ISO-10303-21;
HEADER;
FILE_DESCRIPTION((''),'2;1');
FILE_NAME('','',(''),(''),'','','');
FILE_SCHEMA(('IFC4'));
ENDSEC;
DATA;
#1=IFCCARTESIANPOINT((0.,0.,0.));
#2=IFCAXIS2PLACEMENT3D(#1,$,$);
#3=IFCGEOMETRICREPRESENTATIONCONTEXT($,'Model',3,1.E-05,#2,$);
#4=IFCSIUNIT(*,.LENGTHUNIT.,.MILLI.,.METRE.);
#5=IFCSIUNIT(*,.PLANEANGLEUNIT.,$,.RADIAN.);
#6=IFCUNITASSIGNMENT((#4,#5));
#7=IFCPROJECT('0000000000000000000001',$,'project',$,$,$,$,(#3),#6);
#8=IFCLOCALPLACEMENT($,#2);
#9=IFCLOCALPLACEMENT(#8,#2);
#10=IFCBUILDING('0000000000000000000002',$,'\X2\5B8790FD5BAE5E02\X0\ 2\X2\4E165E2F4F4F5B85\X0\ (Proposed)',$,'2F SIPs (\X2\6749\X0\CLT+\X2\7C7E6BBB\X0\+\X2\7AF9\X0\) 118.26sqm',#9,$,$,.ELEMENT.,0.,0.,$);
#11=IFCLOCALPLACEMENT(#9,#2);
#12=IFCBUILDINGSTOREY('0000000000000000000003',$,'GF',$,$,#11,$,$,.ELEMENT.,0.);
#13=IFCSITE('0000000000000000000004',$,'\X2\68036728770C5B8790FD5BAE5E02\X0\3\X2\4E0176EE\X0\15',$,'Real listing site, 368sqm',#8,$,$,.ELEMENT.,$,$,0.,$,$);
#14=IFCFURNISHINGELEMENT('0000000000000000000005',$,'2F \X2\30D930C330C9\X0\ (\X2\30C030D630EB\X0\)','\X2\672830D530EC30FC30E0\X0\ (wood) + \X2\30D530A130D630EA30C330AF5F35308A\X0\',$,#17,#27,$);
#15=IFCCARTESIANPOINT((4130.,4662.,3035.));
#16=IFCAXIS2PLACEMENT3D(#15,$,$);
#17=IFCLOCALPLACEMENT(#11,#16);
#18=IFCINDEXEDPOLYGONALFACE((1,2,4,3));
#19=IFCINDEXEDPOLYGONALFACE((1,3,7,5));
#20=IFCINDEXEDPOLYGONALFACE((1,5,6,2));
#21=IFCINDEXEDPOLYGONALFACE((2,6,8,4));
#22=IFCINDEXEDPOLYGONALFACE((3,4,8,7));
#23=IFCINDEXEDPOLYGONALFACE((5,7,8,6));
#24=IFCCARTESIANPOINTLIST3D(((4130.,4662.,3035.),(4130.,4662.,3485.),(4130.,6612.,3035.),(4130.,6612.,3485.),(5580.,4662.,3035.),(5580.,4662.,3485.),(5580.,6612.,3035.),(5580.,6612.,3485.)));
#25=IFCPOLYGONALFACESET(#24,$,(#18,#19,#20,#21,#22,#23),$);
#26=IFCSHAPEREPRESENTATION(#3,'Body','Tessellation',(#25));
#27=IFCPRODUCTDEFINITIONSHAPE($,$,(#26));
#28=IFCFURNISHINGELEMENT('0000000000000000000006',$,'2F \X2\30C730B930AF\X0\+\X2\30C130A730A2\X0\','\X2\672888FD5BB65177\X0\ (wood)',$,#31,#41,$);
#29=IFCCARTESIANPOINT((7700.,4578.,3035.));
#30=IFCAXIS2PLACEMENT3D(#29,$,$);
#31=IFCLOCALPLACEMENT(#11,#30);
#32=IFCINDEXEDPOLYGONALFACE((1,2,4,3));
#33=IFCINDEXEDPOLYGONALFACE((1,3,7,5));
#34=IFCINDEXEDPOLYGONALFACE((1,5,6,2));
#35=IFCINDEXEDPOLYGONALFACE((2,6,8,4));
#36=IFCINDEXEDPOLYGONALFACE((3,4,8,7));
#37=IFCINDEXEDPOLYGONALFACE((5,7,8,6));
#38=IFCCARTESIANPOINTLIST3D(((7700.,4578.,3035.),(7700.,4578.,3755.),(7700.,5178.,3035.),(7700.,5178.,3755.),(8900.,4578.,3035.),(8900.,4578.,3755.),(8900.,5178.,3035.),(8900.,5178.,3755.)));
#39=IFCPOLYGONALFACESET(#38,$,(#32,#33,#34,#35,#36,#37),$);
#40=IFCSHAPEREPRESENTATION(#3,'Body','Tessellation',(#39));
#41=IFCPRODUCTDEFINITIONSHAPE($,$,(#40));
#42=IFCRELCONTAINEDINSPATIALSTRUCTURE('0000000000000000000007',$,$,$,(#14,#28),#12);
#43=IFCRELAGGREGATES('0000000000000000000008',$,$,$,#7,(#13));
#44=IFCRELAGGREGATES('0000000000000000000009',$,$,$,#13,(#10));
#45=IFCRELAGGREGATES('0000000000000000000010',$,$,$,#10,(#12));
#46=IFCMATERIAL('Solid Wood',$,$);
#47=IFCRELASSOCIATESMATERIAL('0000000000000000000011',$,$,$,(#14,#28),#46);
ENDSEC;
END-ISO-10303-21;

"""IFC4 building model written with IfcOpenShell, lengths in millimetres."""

from ifc_helpers import new_model, si_unit, frame, frame_2d, origin, place, context, project, spatial, rectangle, extrude, material, element, save


model = new_model("IFC4")

# Units and contexts
model_context = context("Model", 3, precision=1e-05, world=origin())
ifc_project = project(units=[si_unit("LENGTHUNIT", "METRE", prefix="MILLI"), si_unit("PLANEANGLEUNIT", "RADIAN")], contexts=[model_context])

# Site, building, storey
site_placement = place(None, origin())
site = spatial("IfcSite", under=ifc_project, at=site_placement, Name="栃木県宇都宮市3丁目15", ObjectType="Real listing site, 368sqm", CompositionType="ELEMENT", RefElevation=0.0)
building_placement = place(site_placement, origin())
building = spatial("IfcBuilding", under=site, at=building_placement, Name="宇都宮市 2世帯住宅 (Proposed)", ObjectType="2F SIPs (杉CLT+籾殻+竹) 118.26sqm", CompositionType="ELEMENT", ElevationOfRefHeight=0.0, ElevationOfTerrain=0.0)
storey_placement = place(building_placement, origin())
storey = spatial("IfcBuildingStorey", under=building, at=storey_placement, Name="GF", CompositionType="ELEMENT", Elevation=0.0)

# Shared definitions
ifc_material_1 = material(Name="Solid Wood")

# Furnishing elements
furnishing_1_placement = place(storey_placement, frame((4130.0, 4662.0, 3035.0)))
element("IfcFurnishingElement", 1, at=furnishing_1_placement, inside=storey, material=ifc_material_1, Name="2F ベッド (ダブル)", Description="木フレーム (wood) + ファブリック張り", context=model_context, shape_type="SweptSolid", body=[
    extrude(rectangle(XDim=1450.0, YDim=1950.0, at=frame_2d((725.0, 975.0))), frame((4130.0, 4662.0, 3035.0)), (0.0, 0.0, 1.0), 450.0),
])
furnishing_2_placement = place(storey_placement, frame((7700.0, 4578.0, 3035.0)))
element("IfcFurnishingElement", 2, at=furnishing_2_placement, inside=storey, material=ifc_material_1, Name="2F デスク+チェア", Description="木製家具 (wood)", context=model_context, shape_type="SweptSolid", body=[
    extrude(rectangle(XDim=1200.0, YDim=600.0, at=frame_2d((600.0, 300.0))), frame((7700.0, 4578.0, 3035.0)), (0.0, 0.0, 1.0), 720.0),
])

save(model, "model.ifc")
